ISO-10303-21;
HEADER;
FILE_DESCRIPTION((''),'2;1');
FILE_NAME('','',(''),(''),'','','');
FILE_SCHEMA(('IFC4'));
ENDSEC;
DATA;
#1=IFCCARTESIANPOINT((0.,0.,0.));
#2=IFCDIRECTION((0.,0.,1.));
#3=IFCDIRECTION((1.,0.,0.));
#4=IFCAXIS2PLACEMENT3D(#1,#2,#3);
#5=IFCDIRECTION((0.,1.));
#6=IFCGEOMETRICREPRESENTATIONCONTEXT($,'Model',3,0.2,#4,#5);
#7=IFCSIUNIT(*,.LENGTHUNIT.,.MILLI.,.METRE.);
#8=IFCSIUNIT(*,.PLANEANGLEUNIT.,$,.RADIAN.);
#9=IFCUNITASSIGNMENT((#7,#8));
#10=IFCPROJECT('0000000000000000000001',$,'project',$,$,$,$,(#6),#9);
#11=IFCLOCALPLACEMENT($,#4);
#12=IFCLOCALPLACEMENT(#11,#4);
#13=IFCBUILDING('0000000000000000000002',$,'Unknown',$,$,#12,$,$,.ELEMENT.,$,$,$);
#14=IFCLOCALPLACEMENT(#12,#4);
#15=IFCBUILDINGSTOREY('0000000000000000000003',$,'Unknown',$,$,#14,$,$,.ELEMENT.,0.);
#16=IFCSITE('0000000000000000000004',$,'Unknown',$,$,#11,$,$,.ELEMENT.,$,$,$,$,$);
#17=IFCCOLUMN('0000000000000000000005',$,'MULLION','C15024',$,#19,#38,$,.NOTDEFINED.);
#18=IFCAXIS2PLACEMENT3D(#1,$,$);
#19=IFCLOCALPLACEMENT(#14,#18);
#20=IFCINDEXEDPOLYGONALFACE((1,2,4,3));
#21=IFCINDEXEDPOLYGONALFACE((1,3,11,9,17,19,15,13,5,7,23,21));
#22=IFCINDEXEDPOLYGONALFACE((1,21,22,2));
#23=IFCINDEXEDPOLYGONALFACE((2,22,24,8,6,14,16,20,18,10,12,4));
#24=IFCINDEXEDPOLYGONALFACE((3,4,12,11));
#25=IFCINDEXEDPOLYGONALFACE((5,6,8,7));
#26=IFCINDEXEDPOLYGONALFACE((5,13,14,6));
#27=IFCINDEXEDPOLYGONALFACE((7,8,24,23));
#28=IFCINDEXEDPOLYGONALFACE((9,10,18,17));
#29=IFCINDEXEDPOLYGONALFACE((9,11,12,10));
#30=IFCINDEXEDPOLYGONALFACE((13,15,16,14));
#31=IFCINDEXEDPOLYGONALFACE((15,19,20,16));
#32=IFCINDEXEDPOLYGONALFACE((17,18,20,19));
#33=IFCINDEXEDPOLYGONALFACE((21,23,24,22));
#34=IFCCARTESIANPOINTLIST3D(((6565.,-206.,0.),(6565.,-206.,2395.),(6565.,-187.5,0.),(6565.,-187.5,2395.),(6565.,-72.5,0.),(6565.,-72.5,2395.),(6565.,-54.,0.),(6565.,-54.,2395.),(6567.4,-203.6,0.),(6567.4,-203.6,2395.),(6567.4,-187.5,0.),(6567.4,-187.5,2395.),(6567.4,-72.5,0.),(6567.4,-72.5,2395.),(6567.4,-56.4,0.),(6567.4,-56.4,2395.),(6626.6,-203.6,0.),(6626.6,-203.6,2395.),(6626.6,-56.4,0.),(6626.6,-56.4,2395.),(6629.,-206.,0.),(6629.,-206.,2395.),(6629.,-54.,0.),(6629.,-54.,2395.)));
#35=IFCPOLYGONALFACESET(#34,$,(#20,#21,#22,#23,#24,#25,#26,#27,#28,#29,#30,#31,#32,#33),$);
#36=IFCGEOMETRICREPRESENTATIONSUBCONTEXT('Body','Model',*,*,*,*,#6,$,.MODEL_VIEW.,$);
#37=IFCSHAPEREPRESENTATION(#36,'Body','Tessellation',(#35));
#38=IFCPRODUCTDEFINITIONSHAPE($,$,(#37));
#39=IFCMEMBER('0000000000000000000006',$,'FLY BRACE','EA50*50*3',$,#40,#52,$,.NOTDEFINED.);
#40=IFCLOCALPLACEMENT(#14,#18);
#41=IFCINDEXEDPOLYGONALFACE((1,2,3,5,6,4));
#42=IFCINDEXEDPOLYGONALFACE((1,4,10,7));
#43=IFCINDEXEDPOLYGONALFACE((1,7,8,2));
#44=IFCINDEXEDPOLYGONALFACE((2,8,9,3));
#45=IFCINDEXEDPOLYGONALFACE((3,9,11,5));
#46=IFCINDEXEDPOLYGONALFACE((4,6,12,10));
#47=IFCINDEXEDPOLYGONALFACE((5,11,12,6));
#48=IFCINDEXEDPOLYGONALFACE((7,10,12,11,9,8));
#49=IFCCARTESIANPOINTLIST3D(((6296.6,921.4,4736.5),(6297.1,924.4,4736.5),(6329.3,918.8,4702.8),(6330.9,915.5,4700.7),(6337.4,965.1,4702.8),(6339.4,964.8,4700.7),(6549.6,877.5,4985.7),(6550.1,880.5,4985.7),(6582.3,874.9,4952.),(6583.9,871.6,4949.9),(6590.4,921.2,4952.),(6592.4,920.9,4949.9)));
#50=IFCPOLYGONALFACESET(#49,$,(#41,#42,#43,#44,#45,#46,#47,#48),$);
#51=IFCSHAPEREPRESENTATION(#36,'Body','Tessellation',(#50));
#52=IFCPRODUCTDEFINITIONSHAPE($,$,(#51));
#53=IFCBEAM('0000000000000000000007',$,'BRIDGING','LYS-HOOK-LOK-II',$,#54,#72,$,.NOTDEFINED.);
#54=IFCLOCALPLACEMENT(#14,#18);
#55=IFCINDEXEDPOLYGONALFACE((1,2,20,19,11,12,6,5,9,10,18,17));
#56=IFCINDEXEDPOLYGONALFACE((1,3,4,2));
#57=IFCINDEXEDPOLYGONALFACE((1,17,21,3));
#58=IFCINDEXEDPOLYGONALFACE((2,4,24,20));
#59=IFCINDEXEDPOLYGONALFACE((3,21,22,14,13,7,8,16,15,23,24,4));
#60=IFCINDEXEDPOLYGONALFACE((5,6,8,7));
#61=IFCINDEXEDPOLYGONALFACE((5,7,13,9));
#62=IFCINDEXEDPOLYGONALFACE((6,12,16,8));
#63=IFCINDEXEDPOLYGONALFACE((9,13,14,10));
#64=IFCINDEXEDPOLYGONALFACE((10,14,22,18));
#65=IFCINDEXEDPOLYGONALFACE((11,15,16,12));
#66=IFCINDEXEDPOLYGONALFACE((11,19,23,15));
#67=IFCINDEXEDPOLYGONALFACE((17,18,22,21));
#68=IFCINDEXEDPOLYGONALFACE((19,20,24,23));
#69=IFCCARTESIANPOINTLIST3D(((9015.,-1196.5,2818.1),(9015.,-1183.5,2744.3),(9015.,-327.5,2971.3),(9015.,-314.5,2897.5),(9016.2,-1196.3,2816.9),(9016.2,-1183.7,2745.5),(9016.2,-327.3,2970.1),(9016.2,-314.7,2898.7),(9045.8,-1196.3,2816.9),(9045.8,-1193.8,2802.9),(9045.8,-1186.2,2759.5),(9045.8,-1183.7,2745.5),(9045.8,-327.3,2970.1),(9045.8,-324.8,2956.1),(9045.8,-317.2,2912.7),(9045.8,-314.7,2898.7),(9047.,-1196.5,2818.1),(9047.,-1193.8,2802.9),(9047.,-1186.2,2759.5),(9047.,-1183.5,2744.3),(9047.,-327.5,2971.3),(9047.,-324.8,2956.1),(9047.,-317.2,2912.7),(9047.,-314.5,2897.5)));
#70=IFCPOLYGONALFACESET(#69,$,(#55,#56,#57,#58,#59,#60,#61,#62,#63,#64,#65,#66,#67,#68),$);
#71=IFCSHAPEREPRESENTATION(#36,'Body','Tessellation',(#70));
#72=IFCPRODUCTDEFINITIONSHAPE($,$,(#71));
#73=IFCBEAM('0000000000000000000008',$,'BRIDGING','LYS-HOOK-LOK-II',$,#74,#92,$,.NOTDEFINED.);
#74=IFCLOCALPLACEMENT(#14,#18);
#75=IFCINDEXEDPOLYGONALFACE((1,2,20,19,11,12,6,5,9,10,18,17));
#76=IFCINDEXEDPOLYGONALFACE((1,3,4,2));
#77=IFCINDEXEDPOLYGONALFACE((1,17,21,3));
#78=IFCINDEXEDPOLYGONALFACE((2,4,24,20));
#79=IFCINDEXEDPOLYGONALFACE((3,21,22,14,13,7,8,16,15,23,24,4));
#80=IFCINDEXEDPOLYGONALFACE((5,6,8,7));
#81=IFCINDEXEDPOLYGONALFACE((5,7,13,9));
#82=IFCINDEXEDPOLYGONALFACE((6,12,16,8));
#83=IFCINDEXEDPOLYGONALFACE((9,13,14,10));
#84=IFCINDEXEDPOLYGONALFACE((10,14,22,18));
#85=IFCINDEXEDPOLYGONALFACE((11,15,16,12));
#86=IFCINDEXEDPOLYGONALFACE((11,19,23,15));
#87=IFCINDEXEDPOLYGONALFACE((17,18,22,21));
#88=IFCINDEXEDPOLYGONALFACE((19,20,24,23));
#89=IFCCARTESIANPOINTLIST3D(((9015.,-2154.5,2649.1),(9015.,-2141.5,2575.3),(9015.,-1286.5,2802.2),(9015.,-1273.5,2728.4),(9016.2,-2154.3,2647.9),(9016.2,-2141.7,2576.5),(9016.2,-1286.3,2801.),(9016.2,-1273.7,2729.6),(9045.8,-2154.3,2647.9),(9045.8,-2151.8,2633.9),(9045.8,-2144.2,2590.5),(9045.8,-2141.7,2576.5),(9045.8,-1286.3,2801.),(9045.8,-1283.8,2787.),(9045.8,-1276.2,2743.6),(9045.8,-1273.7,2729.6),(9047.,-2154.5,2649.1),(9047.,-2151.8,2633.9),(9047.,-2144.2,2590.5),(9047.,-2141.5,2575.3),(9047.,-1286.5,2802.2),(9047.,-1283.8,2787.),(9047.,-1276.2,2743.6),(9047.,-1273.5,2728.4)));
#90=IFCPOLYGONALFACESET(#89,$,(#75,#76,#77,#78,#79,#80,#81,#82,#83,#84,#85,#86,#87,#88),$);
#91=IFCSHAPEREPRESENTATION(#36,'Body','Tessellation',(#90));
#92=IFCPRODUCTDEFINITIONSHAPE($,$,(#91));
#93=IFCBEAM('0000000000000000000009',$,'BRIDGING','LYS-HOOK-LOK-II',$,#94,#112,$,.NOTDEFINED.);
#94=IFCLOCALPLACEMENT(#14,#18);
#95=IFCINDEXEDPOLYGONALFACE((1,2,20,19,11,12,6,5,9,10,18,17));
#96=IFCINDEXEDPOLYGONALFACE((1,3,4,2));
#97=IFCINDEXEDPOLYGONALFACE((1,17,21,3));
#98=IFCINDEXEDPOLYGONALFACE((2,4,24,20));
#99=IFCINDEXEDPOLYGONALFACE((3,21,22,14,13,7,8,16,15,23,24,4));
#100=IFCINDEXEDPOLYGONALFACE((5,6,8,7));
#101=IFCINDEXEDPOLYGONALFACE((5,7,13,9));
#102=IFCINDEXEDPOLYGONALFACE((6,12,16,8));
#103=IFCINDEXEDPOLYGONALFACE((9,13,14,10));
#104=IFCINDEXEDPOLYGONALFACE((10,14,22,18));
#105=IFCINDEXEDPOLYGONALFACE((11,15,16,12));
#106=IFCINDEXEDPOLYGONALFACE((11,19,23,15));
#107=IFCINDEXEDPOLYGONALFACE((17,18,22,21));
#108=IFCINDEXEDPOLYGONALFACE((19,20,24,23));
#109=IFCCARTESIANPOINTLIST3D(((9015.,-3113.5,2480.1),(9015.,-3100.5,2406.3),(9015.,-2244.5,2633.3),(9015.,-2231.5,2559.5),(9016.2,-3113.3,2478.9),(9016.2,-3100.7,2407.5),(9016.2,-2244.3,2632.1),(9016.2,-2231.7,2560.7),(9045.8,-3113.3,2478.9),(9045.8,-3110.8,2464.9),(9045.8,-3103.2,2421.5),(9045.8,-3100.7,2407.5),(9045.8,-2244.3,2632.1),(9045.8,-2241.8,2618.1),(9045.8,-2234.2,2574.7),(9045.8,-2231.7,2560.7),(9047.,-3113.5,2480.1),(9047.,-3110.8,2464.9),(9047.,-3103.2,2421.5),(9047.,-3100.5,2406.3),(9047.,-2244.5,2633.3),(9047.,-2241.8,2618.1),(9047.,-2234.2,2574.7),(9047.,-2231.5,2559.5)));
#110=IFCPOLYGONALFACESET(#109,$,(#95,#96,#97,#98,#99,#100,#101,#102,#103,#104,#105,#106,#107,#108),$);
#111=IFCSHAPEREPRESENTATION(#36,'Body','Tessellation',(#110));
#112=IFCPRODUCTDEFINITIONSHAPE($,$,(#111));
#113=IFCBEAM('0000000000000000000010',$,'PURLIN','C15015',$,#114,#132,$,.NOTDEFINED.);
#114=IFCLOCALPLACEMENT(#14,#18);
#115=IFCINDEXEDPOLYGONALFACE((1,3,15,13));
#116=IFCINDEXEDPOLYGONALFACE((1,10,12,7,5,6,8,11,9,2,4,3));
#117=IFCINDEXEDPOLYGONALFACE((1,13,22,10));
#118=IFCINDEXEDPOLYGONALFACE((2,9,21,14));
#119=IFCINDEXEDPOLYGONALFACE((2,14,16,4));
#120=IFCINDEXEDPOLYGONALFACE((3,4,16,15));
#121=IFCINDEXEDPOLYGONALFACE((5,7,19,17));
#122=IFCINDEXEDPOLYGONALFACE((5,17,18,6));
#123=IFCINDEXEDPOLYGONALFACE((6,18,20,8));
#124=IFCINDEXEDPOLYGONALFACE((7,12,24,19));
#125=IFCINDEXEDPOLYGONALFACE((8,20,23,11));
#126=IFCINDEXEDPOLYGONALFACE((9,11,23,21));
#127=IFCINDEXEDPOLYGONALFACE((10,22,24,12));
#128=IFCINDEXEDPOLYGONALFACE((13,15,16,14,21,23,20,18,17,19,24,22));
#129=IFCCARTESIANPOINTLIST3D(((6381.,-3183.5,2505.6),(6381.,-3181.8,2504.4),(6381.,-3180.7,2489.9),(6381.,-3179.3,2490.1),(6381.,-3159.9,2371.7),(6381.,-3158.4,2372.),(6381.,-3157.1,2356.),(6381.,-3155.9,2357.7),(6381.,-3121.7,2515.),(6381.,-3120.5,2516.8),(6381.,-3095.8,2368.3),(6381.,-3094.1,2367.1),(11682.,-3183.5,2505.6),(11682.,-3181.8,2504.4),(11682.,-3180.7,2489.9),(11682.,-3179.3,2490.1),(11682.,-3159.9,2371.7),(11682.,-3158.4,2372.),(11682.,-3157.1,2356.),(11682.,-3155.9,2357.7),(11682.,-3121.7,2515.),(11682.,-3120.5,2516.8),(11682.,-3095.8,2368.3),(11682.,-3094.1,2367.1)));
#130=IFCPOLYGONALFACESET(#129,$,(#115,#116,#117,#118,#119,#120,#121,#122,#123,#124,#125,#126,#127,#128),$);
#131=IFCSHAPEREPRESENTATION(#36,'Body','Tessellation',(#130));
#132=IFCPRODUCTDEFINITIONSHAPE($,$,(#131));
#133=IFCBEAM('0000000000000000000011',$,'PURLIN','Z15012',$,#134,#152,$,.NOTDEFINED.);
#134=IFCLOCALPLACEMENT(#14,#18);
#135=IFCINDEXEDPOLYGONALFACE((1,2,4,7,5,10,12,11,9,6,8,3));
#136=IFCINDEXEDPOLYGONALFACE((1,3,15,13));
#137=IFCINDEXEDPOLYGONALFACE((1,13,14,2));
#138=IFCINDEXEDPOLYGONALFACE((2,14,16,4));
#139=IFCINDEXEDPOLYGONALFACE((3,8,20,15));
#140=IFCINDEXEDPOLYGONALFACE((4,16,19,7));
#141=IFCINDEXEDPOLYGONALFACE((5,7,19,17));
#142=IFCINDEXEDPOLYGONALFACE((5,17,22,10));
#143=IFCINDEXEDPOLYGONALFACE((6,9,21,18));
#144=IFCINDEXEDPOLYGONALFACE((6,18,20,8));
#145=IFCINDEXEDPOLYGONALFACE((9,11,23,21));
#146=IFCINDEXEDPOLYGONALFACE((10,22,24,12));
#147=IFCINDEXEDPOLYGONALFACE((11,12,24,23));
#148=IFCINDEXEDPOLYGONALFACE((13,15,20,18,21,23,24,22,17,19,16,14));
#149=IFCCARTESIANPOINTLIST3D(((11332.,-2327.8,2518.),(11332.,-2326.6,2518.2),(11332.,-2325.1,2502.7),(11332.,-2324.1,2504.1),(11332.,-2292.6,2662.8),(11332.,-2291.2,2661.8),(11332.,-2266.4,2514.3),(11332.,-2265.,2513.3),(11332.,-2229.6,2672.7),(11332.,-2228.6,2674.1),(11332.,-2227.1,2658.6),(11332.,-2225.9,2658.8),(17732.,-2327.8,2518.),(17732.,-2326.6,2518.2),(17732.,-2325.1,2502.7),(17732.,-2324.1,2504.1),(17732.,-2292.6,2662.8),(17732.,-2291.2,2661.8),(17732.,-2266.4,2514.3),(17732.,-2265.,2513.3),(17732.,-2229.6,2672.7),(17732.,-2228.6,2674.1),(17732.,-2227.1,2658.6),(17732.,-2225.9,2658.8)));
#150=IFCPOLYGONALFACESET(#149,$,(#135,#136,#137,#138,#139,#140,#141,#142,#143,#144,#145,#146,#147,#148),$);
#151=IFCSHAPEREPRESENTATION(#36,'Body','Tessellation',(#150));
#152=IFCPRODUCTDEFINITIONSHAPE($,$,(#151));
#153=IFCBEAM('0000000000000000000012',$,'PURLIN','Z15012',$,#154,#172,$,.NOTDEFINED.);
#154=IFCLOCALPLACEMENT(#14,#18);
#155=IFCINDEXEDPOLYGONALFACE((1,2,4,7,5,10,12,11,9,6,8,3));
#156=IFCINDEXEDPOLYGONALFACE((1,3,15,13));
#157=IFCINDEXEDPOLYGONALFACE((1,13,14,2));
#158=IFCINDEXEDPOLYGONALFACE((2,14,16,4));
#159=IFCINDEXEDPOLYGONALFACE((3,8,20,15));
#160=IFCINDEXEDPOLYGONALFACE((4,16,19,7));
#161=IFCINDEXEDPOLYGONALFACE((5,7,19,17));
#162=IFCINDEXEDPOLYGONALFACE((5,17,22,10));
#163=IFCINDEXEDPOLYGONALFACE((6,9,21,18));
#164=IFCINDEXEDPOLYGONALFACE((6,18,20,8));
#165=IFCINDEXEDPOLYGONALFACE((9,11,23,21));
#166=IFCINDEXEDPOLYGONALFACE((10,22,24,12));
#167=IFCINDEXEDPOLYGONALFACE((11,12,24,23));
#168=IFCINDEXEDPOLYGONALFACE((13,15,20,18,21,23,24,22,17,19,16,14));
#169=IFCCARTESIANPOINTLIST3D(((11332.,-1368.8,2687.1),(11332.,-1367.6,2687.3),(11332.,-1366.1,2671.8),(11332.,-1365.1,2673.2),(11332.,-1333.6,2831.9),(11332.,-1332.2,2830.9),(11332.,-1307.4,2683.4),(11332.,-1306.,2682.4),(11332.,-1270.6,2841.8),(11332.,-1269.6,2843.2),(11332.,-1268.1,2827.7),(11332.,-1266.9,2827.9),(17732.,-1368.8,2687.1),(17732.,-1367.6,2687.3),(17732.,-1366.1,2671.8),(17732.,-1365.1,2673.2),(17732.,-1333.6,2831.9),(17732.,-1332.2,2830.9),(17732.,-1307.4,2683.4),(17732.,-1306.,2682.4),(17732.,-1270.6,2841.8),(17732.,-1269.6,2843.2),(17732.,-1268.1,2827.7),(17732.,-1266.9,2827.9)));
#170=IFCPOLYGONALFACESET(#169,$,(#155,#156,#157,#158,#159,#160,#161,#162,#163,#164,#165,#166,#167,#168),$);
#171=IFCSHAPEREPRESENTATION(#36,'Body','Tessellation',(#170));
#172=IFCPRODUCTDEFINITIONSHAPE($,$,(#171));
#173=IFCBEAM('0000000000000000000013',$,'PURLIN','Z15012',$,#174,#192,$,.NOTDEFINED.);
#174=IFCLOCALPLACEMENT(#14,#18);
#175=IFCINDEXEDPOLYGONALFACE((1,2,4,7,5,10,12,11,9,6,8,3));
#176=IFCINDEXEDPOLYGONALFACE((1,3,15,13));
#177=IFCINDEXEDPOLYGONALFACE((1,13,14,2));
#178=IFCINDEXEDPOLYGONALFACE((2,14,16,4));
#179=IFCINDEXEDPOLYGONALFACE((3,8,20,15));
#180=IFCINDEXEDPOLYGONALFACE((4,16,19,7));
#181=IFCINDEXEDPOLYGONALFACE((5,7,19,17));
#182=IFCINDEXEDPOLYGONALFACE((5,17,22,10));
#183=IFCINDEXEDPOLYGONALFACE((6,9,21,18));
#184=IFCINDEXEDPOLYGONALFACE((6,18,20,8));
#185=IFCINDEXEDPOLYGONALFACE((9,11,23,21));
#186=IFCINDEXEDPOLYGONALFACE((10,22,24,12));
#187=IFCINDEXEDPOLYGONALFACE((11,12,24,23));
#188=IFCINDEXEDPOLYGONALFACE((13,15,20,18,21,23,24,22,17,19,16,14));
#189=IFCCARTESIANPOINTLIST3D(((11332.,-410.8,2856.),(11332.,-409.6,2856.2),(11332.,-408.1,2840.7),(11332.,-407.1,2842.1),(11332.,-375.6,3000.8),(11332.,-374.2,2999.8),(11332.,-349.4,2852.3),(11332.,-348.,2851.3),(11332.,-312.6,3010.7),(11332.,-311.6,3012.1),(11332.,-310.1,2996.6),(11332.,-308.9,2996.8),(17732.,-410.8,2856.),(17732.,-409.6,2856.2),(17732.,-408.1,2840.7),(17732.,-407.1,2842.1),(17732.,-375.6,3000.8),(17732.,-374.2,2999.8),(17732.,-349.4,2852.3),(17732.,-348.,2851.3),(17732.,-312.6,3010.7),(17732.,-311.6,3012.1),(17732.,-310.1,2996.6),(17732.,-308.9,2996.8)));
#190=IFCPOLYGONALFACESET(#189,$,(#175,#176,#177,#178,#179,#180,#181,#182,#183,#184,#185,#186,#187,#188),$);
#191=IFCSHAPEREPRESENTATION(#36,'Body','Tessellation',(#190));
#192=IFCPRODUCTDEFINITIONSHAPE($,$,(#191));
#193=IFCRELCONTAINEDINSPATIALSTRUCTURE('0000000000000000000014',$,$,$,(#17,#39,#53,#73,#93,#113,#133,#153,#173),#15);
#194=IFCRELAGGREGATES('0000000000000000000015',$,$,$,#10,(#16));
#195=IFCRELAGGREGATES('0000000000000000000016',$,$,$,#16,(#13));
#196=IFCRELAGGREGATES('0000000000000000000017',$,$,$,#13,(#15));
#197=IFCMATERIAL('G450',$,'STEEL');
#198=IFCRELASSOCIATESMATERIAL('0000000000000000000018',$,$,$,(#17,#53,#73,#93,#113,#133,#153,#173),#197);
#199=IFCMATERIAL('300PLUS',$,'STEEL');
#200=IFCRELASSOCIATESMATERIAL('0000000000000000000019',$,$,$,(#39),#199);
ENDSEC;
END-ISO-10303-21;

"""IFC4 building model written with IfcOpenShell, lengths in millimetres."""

from ifc_helpers import new_model, si_unit, direction, frame, origin_with_axes, place, context, subcontext, project, spatial, line, indexed_curve, outline, extrude, material, element, save


model = new_model("IFC4")

# Units and contexts
model_context = context("Model", 3, precision=0.2, world=origin_with_axes(), true_north=direction((0.0, 1.0)))
body_context = subcontext(model_context, "Body", "Model", "MODEL_VIEW")
ifc_project = project(units=[si_unit("LENGTHUNIT", "METRE", prefix="MILLI"), si_unit("PLANEANGLEUNIT", "RADIAN")], contexts=[model_context])

# Site, building, storey
site_placement = place(None, origin_with_axes())
site = spatial("IfcSite", under=ifc_project, at=site_placement, Name="Unknown", CompositionType="ELEMENT")
building_placement = place(site_placement, origin_with_axes())
building = spatial("IfcBuilding", under=site, at=building_placement, Name="Unknown", CompositionType="ELEMENT")
storey_placement = place(building_placement, origin_with_axes())
storey = spatial("IfcBuildingStorey", under=building, at=storey_placement, Name="Unknown", CompositionType="ELEMENT", Elevation=0.0)

# Column
ifc_material_1 = material(Name="G450", Category="STEEL")
column_placement = place(storey_placement, frame((6597.0, -130.0, 0.0), z_axis=(-1.0, 0.0, 0.0), x_axis=(0.0, 0.0, 1.0)))
element("IfcColumn", 1, at=column_placement, inside=storey, material=ifc_material_1, Name="MULLION", Description="C15024", PredefinedType="NOTDEFINED", context=body_context, shape_type="SolidModel", body=[
    extrude(outline(indexed_curve([(32.0, -76.0), (32.0, -57.5), (29.6, -57.5), (29.6, -73.6), (-29.6, -73.6), (-29.6, 73.6), (29.6, 73.6), (29.6, 57.5), (32.0, 57.5), (32.0, 76.0), (-32.0, 76.0), (-32.0, -76.0)], segments=[line(1, 2, 3, 4, 5, 6, 7, 8, 9, 10, 11, 12, 1)])), frame((0.0, 0.0, 0.0), z_axis=(-1.0, 0.0, 0.0), x_axis=(0.0, 0.0, 1.0)), (0.0, 0.0, -1.0), 2395.0),
])

# Member
ifc_material_2 = material(Name="300PLUS", Category="STEEL")
member_placement = place(storey_placement, frame((6571.0, 899.2, 4967.8), z_axis=(0.170963, 0.985277, 0.0), x_axis=(-0.707055, 0.122687, -0.696435)))
element("IfcMember", 2, at=member_placement, inside=storey, material=ifc_material_2, Name="FLY BRACE", Description="EA50*50*3", PredefinedType="NOTDEFINED", context=body_context, shape_type="SolidModel", body=[
    extrude(outline(indexed_curve([(-25.0, -25.0), (25.0, -25.0), (25.0, -22.0), (-22.0, -22.0), (-22.0, 25.0), (-25.0, 25.0)], segments=[line(1, 2, 3, 4, 5, 6, 1)])), frame((0.0, 0.0, 0.0), z_axis=(-1.0, 0.0, 0.0), x_axis=(0.0, 0.0, 1.0)), (0.0, 0.0, -1.0), 357.8),
])

# Beams
beam_1_placement = place(storey_placement, frame((9031.0, -1190.0, 2781.2), z_axis=(1.0, 0.0, 0.0), x_axis=(0.0, 0.984813, 0.173617)))
element("IfcBeam", 3, at=beam_1_placement, inside=storey, material=ifc_material_1, Name="BRIDGING", Description="LYS-HOOK-LOK-II", PredefinedType="NOTDEFINED", context=body_context, shape_type="SolidModel", body=[
    extrude(outline(indexed_curve([(16.0, -37.5), (16.0, -22.0), (14.8, -22.0), (14.8, -36.3), (-14.8, -36.3), (-14.8, 36.3), (14.8, 36.3), (14.8, 22.0), (16.0, 22.0), (16.0, 37.5), (-16.0, 37.5), (-16.0, -37.5)], segments=[line(1, 2, 3, 4, 5, 6, 7, 8, 9, 10, 11, 12, 1)])), frame((0.0, 0.0, 0.0), z_axis=(-1.0, 0.0, 0.0), x_axis=(0.0, 0.0, 1.0)), (0.0, 0.0, -1.0), 882.4),
])
beam_2_placement = place(storey_placement, frame((9031.0, -2148.0, 2612.2), z_axis=(1.0, 0.0, 0.0), x_axis=(0.0, 0.984798, 0.173701)))
element("IfcBeam", 4, at=beam_2_placement, inside=storey, material=ifc_material_1, Name="BRIDGING", Description="LYS-HOOK-LOK-II", PredefinedType="NOTDEFINED", context=body_context, shape_type="SolidModel", body=[
    extrude(outline(indexed_curve([(16.0, -37.5), (16.0, -22.0), (14.8, -22.0), (14.8, -36.3), (-14.8, -36.3), (-14.8, 36.3), (14.8, 36.3), (14.8, 22.0), (16.0, 22.0), (16.0, 37.5), (-16.0, 37.5), (-16.0, -37.5)], segments=[line(1, 2, 3, 4, 5, 6, 7, 8, 9, 10, 11, 12, 1)])), frame((0.0, 0.0, 0.0), z_axis=(-1.0, 0.0, 0.0), x_axis=(0.0, 0.0, 1.0)), (0.0, 0.0, -1.0), 881.4),
])
beam_3_placement = place(storey_placement, frame((9031.0, -3107.0, 2443.2), z_axis=(1.0, 0.0, 0.0), x_axis=(0.0, 0.984813, 0.173617)))
element("IfcBeam", 5, at=beam_3_placement, inside=storey, material=ifc_material_1, Name="BRIDGING", Description="LYS-HOOK-LOK-II", PredefinedType="NOTDEFINED", context=body_context, shape_type="SolidModel", body=[
    extrude(outline(indexed_curve([(16.0, -37.5), (16.0, -22.0), (14.8, -22.0), (14.8, -36.3), (-14.8, -36.3), (-14.8, 36.3), (14.8, 36.3), (14.8, 22.0), (16.0, 22.0), (16.0, 37.5), (-16.0, 37.5), (-16.0, -37.5)], segments=[line(1, 2, 3, 4, 5, 6, 7, 8, 9, 10, 11, 12, 1)])), frame((0.0, 0.0, 0.0), z_axis=(-1.0, 0.0, 0.0), x_axis=(0.0, 0.0, 1.0)), (0.0, 0.0, -1.0), 882.4),
])
beam_4_placement = place(storey_placement, frame((6381.0, -3138.8, 2436.4), z_axis=(0.0, -0.984808, -0.173648), x_axis=(1.0, 0.0, 0.0)))
element("IfcBeam", 6, at=beam_4_placement, inside=storey, material=ifc_material_1, Name="PURLIN", Description="C15015", PredefinedType="NOTDEFINED", context=body_context, shape_type="SolidModel", body=[
    extrude(outline(indexed_curve([(32.0, -76.0), (32.0, -60.0), (30.5, -60.0), (30.5, -74.5), (-30.5, -74.5), (-30.5, 74.5), (30.5, 74.5), (30.5, 60.0), (32.0, 60.0), (32.0, 76.0), (-32.0, 76.0), (-32.0, -76.0)], segments=[line(1, 2, 3, 4, 5, 6, 7, 8, 9, 10, 11, 12, 1)])), frame((0.0, 0.0, 0.0), z_axis=(-1.0, 0.0, 0.0), x_axis=(0.0, 0.0, 1.0)), (0.0, 0.0, -1.0), 5301.0),
])
for number, where, z_axis, x_axis, name in (
    (7, (11332.0, -2278.8, 2588.1), (0.0, -0.984808, -0.173648), (1.0, 0.0, 0.0), "PURLIN"),
    (8, (11332.0, -1319.8, 2757.2), (0.0, -0.984808, -0.173648), (1.0, 0.0, 0.0), "PURLIN"),
    (9, (11332.0, -361.8, 2926.1), (0.0, -0.984808, -0.173648), (1.0, 0.0, 0.0), "PURLIN"),
):
    element("IfcBeam", number, at=place(storey_placement, frame(where, z_axis=z_axis, x_axis=x_axis)), inside=storey, material=ifc_material_1, Name=name, Description="Z15012", PredefinedType="NOTDEFINED", context=body_context, shape_type="SolidModel", body=[
        extrude(outline(indexed_curve([(60.4, -76.0), (60.4, -60.5), (59.2, -60.5), (59.2, -74.8), (0.6, -74.8), (0.6, 76.0), (-64.4, 76.0), (-64.4, 60.5), (-63.2, 60.5), (-63.2, 74.8), (-0.6, 74.8), (-0.6, -76.0)], segments=[line(1, 2, 3, 4, 5, 6, 7, 8, 9, 10, 11, 12, 1)])), frame((0.0, 0.0, 0.0), z_axis=(-1.0, 0.0, 0.0), x_axis=(0.0, 0.0, 1.0)), (0.0, 0.0, -1.0), 6400.0),
    ])

save(model, "model.ifc")
